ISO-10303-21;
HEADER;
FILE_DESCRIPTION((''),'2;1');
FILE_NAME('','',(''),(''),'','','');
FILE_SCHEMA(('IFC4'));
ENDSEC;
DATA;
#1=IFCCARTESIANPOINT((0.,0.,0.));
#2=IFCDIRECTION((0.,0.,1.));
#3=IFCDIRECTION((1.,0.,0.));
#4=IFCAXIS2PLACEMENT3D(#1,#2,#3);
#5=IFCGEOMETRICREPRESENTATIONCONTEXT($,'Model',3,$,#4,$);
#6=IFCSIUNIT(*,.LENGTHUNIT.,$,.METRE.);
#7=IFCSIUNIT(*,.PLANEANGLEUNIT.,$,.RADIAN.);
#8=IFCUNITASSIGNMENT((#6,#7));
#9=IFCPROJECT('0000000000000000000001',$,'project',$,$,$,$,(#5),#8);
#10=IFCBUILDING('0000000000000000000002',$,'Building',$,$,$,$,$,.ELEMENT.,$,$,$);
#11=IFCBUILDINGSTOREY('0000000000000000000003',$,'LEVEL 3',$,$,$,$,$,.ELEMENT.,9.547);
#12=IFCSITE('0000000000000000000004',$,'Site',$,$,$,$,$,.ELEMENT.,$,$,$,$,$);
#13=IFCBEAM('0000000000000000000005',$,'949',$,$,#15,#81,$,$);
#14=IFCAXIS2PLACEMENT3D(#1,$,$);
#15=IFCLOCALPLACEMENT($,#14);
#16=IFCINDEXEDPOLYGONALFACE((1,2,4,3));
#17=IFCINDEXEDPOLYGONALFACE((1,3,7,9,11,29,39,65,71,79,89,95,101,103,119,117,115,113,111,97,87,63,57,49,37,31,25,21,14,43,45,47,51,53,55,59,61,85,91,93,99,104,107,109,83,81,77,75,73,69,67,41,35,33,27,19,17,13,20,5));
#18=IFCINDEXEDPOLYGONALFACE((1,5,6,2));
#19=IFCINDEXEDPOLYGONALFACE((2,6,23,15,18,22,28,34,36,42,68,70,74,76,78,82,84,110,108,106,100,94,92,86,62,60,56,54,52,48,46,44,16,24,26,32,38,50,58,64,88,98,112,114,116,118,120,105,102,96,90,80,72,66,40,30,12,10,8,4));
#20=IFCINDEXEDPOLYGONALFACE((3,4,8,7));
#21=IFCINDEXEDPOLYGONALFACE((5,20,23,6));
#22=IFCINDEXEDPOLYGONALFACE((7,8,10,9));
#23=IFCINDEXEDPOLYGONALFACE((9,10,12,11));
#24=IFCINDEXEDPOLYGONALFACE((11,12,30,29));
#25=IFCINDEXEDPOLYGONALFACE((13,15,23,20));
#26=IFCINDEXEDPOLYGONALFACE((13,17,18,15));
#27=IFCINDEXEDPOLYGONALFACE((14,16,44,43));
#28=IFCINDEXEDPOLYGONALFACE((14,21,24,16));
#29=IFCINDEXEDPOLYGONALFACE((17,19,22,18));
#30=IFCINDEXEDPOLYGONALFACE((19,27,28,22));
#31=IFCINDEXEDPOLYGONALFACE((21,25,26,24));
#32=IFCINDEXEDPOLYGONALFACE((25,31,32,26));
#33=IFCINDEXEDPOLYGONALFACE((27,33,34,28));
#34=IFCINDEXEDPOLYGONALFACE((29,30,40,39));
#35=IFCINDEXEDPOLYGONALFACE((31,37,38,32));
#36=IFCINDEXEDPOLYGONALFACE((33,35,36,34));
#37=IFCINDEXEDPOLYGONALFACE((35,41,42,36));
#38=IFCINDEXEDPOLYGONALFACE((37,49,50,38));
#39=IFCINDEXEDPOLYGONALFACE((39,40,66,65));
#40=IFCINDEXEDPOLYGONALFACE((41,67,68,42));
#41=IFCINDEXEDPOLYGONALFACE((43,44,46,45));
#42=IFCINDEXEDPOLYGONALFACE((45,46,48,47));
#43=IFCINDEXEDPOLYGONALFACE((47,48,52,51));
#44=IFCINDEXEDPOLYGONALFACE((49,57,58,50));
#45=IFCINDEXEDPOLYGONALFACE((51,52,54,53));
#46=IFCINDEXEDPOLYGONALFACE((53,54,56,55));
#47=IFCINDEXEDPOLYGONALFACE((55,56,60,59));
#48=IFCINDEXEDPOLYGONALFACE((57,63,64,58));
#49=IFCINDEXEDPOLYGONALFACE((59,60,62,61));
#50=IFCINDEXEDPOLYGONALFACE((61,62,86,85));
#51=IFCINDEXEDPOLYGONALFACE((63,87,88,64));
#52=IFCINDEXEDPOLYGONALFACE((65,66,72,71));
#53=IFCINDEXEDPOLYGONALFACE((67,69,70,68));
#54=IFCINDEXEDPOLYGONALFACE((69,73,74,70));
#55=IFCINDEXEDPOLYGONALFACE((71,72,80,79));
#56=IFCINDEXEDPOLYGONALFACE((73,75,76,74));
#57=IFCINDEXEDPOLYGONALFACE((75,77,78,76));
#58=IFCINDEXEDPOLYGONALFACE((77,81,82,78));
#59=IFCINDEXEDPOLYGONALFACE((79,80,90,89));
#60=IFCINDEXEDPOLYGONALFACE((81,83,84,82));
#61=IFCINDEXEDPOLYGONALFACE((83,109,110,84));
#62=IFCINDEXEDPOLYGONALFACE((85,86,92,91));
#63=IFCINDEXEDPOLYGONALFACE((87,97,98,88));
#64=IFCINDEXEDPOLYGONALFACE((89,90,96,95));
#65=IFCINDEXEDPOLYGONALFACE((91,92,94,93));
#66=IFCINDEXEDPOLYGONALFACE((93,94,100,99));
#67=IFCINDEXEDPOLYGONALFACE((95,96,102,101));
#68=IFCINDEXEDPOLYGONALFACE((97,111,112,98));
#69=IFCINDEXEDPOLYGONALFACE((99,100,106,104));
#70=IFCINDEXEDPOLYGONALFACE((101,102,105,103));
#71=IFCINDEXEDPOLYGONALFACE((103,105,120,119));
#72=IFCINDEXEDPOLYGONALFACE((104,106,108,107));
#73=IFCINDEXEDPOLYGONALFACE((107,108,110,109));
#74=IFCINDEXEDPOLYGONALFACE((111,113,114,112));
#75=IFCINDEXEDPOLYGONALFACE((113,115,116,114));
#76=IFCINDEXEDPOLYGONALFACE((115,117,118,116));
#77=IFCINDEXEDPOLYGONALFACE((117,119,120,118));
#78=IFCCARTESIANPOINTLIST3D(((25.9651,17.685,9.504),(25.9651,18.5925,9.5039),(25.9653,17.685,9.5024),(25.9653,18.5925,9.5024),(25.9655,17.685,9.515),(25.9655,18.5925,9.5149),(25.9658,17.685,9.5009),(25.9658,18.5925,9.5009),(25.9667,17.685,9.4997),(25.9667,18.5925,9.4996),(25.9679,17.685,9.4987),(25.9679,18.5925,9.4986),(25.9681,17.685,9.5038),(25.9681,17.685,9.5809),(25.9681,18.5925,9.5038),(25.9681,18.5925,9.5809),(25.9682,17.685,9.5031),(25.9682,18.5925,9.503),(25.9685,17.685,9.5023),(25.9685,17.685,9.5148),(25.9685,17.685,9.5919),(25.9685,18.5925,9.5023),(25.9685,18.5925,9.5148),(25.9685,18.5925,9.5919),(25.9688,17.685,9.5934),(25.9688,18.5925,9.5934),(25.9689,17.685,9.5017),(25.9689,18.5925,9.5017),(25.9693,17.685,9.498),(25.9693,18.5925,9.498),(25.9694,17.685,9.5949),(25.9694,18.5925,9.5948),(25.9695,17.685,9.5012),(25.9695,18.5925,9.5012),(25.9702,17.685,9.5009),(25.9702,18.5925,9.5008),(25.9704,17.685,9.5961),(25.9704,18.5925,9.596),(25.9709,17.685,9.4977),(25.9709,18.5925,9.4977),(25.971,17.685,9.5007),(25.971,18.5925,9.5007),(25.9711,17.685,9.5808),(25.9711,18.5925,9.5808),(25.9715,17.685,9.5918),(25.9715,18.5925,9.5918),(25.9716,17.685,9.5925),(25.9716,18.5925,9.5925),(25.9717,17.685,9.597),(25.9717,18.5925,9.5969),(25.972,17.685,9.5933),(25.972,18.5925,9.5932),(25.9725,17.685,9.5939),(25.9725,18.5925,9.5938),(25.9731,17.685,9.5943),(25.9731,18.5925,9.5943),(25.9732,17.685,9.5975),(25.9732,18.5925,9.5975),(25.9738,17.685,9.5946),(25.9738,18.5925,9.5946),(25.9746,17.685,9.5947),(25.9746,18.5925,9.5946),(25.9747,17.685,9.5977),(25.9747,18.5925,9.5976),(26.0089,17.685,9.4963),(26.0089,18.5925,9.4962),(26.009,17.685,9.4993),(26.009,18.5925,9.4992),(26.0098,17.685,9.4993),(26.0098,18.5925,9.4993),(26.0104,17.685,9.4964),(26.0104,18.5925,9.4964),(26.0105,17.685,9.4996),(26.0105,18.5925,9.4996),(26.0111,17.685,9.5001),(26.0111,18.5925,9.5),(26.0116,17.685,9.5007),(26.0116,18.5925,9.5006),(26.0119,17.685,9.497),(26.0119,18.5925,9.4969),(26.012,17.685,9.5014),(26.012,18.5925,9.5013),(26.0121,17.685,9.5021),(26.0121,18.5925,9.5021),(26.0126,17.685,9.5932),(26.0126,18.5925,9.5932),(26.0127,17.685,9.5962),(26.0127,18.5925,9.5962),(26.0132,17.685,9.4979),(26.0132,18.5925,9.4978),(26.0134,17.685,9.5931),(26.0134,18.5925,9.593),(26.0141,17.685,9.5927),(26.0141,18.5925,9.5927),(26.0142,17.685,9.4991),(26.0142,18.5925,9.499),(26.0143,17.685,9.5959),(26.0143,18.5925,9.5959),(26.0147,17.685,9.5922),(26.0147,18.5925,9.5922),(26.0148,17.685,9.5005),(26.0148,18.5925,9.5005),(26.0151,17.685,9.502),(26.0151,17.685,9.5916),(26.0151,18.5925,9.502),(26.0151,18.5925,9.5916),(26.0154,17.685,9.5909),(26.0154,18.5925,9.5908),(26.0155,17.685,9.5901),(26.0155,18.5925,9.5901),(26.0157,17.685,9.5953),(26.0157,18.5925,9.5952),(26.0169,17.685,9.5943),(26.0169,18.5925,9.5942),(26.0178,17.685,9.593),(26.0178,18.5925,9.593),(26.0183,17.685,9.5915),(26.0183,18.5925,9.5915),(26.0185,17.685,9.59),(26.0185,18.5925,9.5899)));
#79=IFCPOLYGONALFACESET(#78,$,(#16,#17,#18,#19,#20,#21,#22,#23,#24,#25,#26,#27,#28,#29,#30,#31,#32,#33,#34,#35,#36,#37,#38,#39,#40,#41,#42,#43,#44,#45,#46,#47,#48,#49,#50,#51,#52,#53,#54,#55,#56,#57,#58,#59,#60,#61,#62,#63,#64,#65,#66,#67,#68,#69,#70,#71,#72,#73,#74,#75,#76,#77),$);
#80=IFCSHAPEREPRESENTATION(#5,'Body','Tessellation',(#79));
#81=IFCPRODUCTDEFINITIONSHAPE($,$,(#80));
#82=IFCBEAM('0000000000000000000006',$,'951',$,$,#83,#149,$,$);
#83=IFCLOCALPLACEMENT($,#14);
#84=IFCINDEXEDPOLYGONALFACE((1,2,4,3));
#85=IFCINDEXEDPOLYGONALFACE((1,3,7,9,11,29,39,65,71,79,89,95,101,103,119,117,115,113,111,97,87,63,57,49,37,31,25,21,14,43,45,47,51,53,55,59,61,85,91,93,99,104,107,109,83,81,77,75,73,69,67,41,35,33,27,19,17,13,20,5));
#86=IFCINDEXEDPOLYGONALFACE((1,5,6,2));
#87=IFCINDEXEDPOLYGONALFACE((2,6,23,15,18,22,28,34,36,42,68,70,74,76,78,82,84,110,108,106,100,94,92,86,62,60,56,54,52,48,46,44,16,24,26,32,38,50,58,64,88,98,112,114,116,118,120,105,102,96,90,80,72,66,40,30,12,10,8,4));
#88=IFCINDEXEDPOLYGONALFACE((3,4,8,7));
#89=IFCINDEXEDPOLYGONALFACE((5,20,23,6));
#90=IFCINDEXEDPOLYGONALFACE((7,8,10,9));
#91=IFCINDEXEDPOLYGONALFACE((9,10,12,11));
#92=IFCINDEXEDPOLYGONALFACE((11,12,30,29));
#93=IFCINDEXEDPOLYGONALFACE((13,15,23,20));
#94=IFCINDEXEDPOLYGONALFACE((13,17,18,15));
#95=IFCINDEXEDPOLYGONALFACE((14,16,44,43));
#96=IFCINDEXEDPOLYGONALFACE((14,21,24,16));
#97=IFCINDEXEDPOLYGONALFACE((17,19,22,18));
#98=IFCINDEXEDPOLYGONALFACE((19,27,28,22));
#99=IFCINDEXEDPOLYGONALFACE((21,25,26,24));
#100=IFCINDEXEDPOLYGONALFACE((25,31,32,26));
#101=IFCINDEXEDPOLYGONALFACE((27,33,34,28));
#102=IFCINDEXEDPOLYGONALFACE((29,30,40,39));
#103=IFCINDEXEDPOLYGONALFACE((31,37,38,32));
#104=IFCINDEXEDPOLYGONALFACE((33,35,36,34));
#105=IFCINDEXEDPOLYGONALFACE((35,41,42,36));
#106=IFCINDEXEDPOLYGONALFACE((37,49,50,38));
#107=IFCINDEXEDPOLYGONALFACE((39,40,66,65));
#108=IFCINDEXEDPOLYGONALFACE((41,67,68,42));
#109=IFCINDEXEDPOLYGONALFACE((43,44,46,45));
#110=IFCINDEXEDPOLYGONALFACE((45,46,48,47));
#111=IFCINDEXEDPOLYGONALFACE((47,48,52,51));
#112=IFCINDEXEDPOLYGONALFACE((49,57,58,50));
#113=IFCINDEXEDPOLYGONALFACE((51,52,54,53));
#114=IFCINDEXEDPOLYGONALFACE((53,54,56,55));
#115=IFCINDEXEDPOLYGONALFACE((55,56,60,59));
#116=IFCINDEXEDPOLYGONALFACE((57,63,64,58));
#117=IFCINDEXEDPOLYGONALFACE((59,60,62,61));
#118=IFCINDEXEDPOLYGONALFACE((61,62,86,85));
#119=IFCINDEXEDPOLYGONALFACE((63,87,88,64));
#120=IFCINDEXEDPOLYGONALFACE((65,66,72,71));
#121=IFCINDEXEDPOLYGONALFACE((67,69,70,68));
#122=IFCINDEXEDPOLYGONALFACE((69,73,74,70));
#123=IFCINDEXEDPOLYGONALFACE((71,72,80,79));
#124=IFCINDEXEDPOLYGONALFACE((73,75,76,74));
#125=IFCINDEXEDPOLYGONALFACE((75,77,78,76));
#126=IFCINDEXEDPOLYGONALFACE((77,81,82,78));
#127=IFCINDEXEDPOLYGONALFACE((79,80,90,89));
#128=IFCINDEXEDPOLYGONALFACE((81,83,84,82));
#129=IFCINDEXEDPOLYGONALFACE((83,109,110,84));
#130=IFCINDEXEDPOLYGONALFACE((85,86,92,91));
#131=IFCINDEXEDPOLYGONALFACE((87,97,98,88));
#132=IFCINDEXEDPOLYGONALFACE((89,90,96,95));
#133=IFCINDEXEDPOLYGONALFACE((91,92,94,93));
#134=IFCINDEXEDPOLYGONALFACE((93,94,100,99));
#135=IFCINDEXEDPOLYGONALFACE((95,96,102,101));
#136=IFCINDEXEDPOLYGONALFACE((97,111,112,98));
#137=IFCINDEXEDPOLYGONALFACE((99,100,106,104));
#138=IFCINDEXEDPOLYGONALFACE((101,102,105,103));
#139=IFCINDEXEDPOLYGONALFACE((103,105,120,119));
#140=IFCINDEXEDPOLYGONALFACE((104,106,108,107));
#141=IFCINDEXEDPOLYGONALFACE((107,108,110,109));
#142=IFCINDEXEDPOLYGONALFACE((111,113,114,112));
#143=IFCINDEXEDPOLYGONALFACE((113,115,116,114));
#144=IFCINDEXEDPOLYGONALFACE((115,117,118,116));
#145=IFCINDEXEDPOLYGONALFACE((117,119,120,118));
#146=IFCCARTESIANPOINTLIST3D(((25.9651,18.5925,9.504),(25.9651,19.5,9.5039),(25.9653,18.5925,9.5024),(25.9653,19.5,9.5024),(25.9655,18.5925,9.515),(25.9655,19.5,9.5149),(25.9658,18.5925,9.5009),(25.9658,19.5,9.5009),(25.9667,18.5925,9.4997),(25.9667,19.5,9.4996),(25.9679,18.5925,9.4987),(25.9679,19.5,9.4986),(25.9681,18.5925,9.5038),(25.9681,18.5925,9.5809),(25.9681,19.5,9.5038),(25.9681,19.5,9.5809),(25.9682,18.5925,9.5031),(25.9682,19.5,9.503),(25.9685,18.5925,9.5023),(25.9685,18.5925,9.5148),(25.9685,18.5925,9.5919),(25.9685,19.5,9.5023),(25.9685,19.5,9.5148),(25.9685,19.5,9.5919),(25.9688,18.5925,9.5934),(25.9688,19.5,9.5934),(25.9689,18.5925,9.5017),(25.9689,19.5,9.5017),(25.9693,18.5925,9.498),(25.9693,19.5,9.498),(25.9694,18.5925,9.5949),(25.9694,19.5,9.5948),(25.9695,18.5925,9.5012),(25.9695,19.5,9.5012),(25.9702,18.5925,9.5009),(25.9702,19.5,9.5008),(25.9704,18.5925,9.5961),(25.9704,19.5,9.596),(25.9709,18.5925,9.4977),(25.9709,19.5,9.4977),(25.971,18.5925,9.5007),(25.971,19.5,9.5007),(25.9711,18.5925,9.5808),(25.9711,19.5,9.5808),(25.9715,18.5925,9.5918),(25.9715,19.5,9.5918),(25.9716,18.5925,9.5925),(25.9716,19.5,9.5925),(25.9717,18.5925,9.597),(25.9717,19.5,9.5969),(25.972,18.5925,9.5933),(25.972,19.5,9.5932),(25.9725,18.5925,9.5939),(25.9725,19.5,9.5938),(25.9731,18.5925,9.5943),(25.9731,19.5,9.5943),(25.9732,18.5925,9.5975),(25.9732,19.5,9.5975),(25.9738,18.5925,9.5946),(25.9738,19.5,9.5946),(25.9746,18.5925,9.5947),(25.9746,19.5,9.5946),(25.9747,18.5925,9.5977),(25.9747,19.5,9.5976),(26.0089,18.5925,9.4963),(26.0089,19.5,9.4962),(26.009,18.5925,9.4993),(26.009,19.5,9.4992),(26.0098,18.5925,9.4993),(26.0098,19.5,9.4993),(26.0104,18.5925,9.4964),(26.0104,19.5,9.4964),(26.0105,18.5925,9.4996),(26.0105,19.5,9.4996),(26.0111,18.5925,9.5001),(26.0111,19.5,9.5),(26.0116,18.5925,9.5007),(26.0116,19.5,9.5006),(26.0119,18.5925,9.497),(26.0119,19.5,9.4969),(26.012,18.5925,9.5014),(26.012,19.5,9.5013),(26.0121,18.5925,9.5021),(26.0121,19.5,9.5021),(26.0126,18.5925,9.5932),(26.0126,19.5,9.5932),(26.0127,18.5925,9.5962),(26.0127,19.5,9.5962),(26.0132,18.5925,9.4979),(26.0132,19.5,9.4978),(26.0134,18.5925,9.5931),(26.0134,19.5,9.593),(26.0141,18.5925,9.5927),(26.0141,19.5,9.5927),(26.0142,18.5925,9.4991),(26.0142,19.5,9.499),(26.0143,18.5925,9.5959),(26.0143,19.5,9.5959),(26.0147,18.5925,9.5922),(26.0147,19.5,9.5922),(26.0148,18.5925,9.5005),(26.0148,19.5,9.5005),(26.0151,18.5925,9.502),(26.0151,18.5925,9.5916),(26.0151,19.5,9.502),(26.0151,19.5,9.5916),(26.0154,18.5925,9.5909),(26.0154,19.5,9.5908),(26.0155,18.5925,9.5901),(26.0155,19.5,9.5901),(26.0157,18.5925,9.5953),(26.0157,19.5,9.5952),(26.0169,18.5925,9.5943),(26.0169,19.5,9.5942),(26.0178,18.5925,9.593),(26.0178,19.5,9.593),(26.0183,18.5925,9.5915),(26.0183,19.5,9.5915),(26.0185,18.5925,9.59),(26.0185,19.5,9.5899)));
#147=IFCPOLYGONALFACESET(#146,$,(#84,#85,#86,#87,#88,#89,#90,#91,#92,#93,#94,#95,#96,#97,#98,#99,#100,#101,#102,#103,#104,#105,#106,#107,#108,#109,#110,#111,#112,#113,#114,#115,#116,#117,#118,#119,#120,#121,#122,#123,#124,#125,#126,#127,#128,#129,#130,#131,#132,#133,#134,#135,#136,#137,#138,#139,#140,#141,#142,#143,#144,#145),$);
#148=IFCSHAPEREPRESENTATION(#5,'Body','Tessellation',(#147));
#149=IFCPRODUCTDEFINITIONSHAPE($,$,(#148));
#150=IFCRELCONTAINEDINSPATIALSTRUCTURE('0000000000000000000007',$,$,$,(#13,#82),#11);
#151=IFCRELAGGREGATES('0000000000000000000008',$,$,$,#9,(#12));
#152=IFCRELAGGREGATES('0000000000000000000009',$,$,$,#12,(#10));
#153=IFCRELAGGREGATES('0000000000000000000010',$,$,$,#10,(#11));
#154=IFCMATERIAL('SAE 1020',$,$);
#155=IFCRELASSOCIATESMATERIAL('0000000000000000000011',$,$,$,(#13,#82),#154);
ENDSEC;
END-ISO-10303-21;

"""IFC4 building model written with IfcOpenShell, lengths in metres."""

from ifc_helpers import new_model, si_unit, frame, origin_with_axes, origin_2d_with_axis, place, context, project, spatial, c_section, extrude, material, material_profile, profile_set, profile_usage, element, save


model = new_model("IFC4")

# Units and contexts
model_context = context("Model", 3, world=origin_with_axes())
ifc_project = project(units=[si_unit("LENGTHUNIT", "METRE"), si_unit("PLANEANGLEUNIT", "RADIAN")], contexts=[model_context])

# Site, building, storey
site = spatial("IfcSite", under=ifc_project, Name="Site", CompositionType="ELEMENT")
building = spatial("IfcBuilding", under=site, Name="Building", CompositionType="ELEMENT")
storey = spatial("IfcBuildingStorey", under=building, Name="LEVEL 3", CompositionType="ELEMENT", Elevation=9.547)

# Beams
ifc_material = material(Name="SAE 1020")
ifc_material_profile_1 = material_profile(ifc_material, c_section(Depth=0.1, Width=0.05, WallThickness=0.003, Girth=0.017, InternalFilletRadius=0.003, at=origin_2d_with_axis()))
ifc_profile_set_1 = profile_set([ifc_material_profile_1])
ifc_profile_usage_1 = profile_usage(ifc_profile_set_1, cardinal=10)
beam_1_placement = place(None, frame((25.9918, 17.685, 9.547), z_axis=(0.0, 1.0, -0.00003), x_axis=(-0.999256, 0.000001, 0.038562)))
element("IfcBeam", 1, at=beam_1_placement, inside=storey, material=ifc_profile_usage_1, Name="949", context=model_context, shape_type="SweptSolid", body=[
    extrude(c_section(Depth=0.1, Width=0.05, WallThickness=0.003, Girth=0.017, InternalFilletRadius=0.003, at=origin_2d_with_axis()), origin_with_axes(), (0.0, 0.0, 1.0), 0.9075),
])
ifc_material_profile_2 = material_profile(ifc_material, c_section(Depth=0.1, Width=0.05, WallThickness=0.003, Girth=0.017, InternalFilletRadius=0.003, at=origin_2d_with_axis()))
ifc_profile_set_2 = profile_set([ifc_material_profile_2])
ifc_profile_usage_2 = profile_usage(ifc_profile_set_2, cardinal=10)
beam_2_placement = place(None, frame((25.9918, 18.5925, 9.547), z_axis=(0.0, 1.0, -0.00003), x_axis=(-0.999256, 0.000001, 0.038562)))
element("IfcBeam", 2, at=beam_2_placement, inside=storey, material=ifc_profile_usage_2, Name="951", context=model_context, shape_type="SweptSolid", body=[
    extrude(c_section(Depth=0.1, Width=0.05, WallThickness=0.003, Girth=0.017, InternalFilletRadius=0.003, at=origin_2d_with_axis()), origin_with_axes(), (0.0, 0.0, 1.0), 0.9075),
])

save(model, "model.ifc")
